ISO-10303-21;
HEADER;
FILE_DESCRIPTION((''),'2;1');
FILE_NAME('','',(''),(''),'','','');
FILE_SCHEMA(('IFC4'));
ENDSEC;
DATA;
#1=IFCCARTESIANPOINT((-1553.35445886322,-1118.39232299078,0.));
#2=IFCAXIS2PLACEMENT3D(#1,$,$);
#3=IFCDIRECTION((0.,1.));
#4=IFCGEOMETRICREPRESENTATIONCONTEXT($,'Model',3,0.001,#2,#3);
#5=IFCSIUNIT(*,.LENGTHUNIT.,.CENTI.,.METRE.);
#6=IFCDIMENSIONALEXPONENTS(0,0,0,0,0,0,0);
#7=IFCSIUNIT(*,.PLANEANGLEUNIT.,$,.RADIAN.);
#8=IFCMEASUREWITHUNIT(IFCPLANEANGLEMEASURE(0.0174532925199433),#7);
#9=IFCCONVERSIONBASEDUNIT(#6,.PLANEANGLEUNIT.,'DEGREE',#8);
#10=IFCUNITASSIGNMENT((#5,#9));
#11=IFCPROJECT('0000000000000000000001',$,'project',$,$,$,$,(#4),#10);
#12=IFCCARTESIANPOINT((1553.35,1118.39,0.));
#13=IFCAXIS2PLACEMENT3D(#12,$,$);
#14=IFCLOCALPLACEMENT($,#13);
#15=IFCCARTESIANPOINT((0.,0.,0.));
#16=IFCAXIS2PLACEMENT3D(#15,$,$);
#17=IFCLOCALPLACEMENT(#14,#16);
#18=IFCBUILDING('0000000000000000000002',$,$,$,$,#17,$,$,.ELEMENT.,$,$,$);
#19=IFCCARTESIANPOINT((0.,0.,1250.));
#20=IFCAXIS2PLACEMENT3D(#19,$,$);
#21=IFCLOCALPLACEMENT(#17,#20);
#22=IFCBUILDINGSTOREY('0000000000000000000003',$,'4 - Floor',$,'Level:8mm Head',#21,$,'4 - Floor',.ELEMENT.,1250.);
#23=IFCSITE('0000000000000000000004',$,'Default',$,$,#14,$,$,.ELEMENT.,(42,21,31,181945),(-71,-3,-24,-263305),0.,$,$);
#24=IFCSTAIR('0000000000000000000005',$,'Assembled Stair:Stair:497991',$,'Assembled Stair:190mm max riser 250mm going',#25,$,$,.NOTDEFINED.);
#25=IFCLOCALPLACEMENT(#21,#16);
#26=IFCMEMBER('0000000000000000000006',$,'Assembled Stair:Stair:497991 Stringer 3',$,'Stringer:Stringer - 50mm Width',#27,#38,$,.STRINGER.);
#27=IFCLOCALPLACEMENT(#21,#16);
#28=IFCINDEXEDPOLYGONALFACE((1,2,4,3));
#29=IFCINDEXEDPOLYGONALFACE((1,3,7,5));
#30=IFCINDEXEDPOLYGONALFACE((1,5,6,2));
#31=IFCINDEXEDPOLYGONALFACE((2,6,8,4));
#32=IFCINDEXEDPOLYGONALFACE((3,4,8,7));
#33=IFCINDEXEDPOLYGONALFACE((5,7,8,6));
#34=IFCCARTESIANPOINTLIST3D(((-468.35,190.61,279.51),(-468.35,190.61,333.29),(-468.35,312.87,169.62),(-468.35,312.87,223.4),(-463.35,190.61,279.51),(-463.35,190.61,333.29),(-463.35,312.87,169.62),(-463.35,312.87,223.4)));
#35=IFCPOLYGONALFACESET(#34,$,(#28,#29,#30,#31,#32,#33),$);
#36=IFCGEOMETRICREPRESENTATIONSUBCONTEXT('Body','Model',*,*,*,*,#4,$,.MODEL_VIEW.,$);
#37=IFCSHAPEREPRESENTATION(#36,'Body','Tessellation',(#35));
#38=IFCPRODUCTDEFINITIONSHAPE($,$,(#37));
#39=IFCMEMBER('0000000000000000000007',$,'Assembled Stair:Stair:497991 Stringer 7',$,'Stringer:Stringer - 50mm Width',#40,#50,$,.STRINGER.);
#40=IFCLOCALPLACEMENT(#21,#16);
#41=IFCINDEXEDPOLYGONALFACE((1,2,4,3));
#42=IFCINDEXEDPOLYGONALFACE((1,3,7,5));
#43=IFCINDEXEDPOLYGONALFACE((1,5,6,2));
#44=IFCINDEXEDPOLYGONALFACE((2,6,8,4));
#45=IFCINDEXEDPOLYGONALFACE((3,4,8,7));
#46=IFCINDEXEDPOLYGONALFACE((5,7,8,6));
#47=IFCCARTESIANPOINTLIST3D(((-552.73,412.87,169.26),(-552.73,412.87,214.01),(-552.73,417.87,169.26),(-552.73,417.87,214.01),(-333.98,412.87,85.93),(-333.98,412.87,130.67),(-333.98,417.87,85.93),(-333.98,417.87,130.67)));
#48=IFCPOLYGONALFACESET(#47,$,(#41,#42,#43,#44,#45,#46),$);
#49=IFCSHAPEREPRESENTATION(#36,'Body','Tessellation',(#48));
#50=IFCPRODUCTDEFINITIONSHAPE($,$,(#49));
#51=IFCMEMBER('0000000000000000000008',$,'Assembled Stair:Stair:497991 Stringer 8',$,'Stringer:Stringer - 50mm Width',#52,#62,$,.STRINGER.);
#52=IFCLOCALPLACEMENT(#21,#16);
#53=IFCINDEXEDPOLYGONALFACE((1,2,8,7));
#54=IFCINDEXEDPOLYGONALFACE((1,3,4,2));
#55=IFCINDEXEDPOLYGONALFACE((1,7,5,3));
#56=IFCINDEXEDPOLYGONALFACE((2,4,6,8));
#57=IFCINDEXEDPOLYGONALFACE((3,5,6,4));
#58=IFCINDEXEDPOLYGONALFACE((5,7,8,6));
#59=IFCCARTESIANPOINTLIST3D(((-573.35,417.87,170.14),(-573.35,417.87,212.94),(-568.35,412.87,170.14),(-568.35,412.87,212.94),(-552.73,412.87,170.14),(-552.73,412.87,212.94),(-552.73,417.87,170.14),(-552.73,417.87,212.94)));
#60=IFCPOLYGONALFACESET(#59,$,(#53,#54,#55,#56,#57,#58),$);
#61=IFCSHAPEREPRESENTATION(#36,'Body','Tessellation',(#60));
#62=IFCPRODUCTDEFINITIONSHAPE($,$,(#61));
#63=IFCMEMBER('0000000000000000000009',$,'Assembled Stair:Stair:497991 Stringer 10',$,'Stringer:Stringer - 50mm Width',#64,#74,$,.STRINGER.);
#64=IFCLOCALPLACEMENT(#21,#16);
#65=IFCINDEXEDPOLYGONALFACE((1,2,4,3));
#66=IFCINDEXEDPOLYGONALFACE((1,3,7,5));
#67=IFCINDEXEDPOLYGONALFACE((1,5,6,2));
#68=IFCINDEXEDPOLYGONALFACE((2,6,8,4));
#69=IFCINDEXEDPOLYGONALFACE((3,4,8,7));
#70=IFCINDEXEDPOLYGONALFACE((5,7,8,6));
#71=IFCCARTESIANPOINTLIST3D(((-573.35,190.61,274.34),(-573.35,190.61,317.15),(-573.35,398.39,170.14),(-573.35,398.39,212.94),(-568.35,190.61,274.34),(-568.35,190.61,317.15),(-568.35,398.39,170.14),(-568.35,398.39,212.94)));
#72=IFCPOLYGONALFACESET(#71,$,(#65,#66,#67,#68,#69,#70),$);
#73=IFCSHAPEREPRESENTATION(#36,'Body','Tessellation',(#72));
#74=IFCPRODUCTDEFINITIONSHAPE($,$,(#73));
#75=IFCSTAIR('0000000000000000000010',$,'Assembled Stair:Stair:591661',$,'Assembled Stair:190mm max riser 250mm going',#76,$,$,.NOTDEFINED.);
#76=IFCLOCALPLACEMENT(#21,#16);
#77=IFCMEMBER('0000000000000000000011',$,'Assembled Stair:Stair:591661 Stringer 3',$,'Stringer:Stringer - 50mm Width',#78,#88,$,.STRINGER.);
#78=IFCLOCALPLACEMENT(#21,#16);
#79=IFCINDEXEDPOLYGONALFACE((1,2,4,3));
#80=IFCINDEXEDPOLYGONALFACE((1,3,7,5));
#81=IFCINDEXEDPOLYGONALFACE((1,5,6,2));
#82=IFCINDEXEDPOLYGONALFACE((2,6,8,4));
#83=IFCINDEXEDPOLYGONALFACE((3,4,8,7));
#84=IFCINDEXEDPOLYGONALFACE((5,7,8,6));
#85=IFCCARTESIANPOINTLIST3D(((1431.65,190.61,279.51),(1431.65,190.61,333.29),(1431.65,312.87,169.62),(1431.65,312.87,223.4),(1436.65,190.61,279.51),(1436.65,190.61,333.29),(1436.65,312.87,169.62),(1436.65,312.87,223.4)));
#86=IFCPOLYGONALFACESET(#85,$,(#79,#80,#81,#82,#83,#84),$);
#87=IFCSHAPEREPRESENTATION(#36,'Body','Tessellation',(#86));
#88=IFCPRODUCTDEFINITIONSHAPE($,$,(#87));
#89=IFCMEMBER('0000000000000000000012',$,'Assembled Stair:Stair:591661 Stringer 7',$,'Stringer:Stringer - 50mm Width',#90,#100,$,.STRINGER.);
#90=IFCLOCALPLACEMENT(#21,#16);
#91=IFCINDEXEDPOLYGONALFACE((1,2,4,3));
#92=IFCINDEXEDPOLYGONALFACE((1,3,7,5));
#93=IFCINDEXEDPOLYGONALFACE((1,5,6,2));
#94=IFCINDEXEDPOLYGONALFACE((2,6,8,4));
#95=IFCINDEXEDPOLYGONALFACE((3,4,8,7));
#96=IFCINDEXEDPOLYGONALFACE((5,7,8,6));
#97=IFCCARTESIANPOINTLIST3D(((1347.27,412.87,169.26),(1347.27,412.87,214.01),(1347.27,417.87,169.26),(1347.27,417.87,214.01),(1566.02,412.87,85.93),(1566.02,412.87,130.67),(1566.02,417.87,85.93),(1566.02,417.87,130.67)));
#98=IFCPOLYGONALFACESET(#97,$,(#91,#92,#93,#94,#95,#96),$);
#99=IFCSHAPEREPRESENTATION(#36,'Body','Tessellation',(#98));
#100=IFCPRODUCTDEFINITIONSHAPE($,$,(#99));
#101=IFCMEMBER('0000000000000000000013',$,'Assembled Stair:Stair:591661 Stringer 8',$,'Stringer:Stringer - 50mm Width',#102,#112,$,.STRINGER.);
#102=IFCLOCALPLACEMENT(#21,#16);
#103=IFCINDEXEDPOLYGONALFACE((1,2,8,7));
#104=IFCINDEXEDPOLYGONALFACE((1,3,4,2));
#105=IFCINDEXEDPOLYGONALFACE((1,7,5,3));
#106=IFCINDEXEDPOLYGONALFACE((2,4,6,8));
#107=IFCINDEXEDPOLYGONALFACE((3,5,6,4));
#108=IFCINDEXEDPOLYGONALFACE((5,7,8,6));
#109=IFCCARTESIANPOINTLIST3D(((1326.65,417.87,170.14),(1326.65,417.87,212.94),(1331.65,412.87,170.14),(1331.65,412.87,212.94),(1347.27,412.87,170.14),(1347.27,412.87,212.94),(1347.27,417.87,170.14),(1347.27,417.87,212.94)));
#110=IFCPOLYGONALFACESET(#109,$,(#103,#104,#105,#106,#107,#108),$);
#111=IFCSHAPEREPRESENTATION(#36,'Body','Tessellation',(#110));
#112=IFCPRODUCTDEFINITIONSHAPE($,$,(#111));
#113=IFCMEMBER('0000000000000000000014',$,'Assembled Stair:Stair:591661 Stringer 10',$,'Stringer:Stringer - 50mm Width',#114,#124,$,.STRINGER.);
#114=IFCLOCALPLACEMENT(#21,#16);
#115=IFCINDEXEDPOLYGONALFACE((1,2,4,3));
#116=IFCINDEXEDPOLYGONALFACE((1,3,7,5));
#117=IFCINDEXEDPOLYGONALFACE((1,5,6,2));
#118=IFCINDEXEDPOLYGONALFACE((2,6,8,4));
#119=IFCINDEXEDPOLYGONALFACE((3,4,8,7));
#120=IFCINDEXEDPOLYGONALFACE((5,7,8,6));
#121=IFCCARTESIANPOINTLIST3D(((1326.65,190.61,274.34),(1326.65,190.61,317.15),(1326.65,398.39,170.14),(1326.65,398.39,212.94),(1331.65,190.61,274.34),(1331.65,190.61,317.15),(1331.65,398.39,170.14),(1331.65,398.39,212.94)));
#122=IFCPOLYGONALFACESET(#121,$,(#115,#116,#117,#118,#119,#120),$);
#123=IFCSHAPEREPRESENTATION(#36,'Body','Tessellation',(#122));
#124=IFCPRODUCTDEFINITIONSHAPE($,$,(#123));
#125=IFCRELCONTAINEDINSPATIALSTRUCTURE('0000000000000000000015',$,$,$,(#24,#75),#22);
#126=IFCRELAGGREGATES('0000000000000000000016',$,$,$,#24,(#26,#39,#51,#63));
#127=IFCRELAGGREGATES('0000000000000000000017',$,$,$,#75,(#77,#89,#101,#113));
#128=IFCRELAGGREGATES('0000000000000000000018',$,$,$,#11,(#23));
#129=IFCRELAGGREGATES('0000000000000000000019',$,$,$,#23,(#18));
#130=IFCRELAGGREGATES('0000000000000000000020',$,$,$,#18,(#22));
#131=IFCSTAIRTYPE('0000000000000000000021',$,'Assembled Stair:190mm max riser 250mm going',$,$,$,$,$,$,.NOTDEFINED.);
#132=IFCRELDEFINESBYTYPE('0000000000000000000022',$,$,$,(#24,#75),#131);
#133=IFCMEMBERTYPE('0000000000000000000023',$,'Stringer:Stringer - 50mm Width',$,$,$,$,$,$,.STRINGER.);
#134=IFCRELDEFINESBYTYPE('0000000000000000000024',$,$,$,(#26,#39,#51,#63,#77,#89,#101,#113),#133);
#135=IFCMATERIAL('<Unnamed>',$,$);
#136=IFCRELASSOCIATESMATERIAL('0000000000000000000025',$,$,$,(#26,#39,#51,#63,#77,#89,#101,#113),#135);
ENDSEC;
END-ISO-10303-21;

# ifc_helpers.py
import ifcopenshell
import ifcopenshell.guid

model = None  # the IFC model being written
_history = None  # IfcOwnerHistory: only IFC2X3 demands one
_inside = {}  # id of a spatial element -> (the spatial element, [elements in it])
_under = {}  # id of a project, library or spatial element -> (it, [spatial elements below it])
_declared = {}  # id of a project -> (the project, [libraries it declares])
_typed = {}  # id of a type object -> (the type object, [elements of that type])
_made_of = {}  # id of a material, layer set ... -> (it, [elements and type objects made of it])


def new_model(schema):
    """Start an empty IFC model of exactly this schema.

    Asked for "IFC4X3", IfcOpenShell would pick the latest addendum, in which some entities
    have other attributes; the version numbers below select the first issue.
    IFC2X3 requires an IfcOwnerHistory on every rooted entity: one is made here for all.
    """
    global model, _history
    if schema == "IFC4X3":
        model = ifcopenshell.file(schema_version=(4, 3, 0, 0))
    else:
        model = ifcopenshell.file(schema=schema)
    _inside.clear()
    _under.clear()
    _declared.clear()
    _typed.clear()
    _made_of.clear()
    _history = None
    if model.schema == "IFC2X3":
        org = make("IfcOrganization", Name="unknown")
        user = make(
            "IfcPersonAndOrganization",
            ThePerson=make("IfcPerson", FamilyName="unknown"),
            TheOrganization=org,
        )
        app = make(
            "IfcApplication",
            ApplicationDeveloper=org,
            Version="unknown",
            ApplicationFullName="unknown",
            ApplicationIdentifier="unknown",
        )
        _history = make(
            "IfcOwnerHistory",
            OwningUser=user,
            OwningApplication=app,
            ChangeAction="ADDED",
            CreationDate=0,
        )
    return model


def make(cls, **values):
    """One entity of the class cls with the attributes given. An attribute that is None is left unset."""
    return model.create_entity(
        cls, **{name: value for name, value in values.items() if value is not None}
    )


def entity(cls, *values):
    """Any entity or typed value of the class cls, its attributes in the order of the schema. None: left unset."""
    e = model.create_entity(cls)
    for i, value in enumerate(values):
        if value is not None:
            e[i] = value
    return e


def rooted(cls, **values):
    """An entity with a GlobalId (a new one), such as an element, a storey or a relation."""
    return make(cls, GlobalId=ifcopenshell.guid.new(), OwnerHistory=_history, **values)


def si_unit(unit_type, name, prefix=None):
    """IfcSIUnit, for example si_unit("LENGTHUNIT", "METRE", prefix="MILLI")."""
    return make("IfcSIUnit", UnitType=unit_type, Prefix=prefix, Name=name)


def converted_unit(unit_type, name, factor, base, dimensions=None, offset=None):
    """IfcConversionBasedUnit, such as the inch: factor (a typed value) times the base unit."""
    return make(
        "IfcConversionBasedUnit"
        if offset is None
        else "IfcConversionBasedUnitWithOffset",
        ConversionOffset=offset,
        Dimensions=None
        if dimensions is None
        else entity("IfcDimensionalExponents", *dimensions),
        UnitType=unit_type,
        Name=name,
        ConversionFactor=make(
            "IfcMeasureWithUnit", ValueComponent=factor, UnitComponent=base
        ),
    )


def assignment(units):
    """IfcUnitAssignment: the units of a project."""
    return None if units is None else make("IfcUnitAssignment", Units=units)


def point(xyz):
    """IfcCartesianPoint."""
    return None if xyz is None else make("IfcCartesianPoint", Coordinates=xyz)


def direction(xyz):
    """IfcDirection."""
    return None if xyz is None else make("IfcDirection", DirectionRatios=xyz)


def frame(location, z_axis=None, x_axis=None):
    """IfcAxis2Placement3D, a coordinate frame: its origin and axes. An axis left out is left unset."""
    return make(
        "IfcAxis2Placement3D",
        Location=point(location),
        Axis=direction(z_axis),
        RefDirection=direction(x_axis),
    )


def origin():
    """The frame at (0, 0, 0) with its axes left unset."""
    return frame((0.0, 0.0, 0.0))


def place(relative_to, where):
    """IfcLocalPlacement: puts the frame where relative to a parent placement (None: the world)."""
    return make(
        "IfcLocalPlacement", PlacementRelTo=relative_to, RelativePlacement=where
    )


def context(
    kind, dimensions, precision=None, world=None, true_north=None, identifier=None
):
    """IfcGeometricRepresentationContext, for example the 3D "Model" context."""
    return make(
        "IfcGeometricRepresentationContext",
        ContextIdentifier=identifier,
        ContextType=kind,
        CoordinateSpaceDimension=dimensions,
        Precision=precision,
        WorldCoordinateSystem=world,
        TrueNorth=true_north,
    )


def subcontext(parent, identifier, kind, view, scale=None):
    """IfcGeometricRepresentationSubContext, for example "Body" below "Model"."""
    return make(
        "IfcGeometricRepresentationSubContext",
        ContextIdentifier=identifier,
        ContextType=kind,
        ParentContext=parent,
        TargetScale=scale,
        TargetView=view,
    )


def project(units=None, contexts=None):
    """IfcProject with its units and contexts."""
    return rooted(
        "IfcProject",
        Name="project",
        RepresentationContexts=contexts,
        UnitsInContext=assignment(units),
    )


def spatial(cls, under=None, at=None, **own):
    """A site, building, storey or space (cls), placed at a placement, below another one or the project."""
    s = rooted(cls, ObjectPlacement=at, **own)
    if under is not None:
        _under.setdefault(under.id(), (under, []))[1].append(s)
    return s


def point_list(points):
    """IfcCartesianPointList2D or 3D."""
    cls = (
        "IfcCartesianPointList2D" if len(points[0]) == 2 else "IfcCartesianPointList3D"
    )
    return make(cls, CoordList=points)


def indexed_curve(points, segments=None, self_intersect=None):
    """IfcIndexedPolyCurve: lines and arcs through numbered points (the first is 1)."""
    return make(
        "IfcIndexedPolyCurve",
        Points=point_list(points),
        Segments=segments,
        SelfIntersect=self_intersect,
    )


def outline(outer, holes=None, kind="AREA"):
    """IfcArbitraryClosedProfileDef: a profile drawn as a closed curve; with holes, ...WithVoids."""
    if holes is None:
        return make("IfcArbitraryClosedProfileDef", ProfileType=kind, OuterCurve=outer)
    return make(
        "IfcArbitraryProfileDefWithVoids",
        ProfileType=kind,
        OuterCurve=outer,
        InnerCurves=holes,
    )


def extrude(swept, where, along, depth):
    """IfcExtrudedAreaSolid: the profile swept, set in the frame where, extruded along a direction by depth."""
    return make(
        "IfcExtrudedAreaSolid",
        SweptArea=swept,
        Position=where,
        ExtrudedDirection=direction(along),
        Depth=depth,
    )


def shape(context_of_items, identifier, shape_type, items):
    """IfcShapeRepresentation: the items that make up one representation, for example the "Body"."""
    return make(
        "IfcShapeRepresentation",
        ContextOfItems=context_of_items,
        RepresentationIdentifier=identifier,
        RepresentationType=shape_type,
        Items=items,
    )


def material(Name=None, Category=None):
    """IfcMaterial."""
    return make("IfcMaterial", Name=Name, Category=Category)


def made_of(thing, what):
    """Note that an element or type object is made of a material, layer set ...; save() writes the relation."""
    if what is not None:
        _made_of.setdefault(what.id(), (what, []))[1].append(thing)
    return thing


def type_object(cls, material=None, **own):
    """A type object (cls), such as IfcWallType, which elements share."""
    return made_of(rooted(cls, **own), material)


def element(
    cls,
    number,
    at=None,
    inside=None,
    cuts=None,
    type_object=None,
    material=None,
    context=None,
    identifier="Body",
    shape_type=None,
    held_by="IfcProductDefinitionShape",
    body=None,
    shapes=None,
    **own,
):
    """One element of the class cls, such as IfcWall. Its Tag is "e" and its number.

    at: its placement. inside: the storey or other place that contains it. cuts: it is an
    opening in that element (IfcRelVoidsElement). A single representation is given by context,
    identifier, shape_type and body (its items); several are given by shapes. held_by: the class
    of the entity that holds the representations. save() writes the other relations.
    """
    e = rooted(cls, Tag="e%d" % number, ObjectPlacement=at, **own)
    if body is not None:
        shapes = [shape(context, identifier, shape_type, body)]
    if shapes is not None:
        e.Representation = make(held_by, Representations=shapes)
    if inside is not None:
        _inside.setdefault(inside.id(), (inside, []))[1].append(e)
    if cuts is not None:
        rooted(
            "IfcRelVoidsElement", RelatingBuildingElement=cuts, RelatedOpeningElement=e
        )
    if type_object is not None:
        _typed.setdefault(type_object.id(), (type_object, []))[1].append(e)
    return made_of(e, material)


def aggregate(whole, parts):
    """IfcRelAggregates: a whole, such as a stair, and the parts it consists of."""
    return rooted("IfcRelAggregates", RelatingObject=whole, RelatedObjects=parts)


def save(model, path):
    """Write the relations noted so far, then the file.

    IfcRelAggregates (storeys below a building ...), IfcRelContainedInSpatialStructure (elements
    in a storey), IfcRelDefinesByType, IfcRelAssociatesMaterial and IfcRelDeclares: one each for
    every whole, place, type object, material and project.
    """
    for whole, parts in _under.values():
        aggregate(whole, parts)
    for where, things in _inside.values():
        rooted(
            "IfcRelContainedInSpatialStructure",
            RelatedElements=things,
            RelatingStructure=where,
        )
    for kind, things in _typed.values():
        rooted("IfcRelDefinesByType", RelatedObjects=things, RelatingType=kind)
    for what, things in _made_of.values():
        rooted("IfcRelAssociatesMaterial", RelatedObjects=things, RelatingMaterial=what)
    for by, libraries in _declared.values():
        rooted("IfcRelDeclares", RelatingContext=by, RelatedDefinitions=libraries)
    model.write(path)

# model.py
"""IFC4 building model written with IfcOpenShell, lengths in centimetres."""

from ifc_helpers import new_model, entity, si_unit, converted_unit, direction, frame, origin, place, context, subcontext, project, spatial, indexed_curve, outline, extrude, material, type_object, element, aggregate, save


model = new_model("IFC4")

# Units and contexts
model_context = context("Model", 3, precision=0.001, world=frame((-1553.35445886322, -1118.39232299078, 0.0)), true_north=direction((0.0, 1.0)))
body_context = subcontext(model_context, "Body", "Model", "MODEL_VIEW")
ifc_project = project(units=[si_unit("LENGTHUNIT", "METRE", prefix="CENTI"), converted_unit("PLANEANGLEUNIT", "DEGREE", entity("IfcPlaneAngleMeasure", 0.0174532925199433), si_unit("PLANEANGLEUNIT", "RADIAN"), dimensions=[0, 0, 0, 0, 0, 0, 0])], contexts=[model_context])

# Site, building, storey
site_placement = place(None, frame((1553.35, 1118.39, 0.0)))
site = spatial("IfcSite", under=ifc_project, at=site_placement, Name="Default", CompositionType="ELEMENT", RefLatitude=(42, 21, 31, 181945), RefLongitude=(-71, -3, -24, -263305), RefElevation=0.0)
building_placement = place(site_placement, origin())
building = spatial("IfcBuilding", under=site, at=building_placement, CompositionType="ELEMENT")
storey_placement = place(building_placement, frame((0.0, 0.0, 1250.0)))
storey = spatial("IfcBuildingStorey", under=building, at=storey_placement, Name="4 - Floor", ObjectType="Level:8mm Head", LongName="4 - Floor", CompositionType="ELEMENT", Elevation=1250.0)

# Stair, members
stair_type = type_object("IfcStairType", Name="Assembled Stair:190mm max riser 250mm going", PredefinedType="NOTDEFINED")
stair_1_placement = place(storey_placement, origin())
stair_1 = element("IfcStair", 1, at=stair_1_placement, inside=storey, type_object=stair_type, Name="Assembled Stair:Stair:497991", ObjectType="Assembled Stair:190mm max riser 250mm going", PredefinedType="NOTDEFINED")
ifc_material = material(Name="<Unnamed>")
member_type = type_object("IfcMemberType", Name="Stringer:Stringer - 50mm Width", PredefinedType="STRINGER")
member_1_placement = place(stair_1_placement, origin())
member_1 = element("IfcMember", 2, at=member_1_placement, type_object=member_type, material=ifc_material, Name="Assembled Stair:Stair:497991 Stringer 3", ObjectType="Stringer:Stringer - 50mm Width", PredefinedType="STRINGER", context=body_context, shape_type="SweptSolid", body=[
    extrude(outline(indexed_curve([(-64.22, -20.0), (100.17, -20.0), (64.22, 20.0), (-100.17, 20.0), (-64.22, -20.0)], self_intersect=False)), frame((-468.35, 251.74, 251.46), z_axis=(1.0, 0.0, 0.0), x_axis=(0.0, -0.74373, 0.668481)), (0.0, 0.0, 1.0), 5.0),
])
member_2_placement = place(stair_1_placement, origin())
member_2 = element("IfcMember", 3, at=member_2_placement, type_object=member_type, material=ifc_material, Name="Assembled Stair:Stair:497991 Stringer 7", ObjectType="Stringer:Stringer - 50mm Width", PredefinedType="STRINGER", context=body_context, shape_type="SweptSolid", body=[
    extrude(outline(indexed_curve([(-125.01, -20.91), (109.08, -20.91), (125.01, 20.91), (-109.08, 20.91), (-125.01, -20.91)], self_intersect=False)), frame((-443.35, 412.87, 149.97), z_axis=(0.0, 1.0, 0.0), x_axis=(-0.934489, 0.0, 0.355992)), (0.0, 0.0, 1.0), 5.0),
])
member_3_placement = place(stair_1_placement, origin())
member_3 = element("IfcMember", 4, at=member_3_placement, type_object=member_type, material=ifc_material, Name="Assembled Stair:Stair:497991 Stringer 8", ObjectType="Stringer:Stringer - 50mm Width", PredefinedType="STRINGER", context=body_context, shape_type="SweptSolid", body=[
    extrude(outline(indexed_curve([(-9.06, -2.5), (11.56, -2.5), (6.56, 2.5), (-9.06, 2.5), (-9.06, -2.5)], self_intersect=False)), frame((-561.79, 415.37, 170.14), z_axis=(0.0, 0.0, 1.0), x_axis=(-1.0, 0.0, 0.0)), (0.0, 0.0, 1.0), 42.8),
])
member_4_placement = place(stair_1_placement, origin())
member_4 = element("IfcMember", 5, at=member_4_placement, type_object=member_type, material=ifc_material, Name="Assembled Stair:Stair:497991 Stringer 10", ObjectType="Stringer:Stringer - 50mm Width", PredefinedType="STRINGER", context=body_context, shape_type="SweptSolid", body=[
    extrude(outline(indexed_curve([(-106.63, -19.13), (125.82, -19.13), (106.63, 19.13), (-125.82, 19.13), (-106.63, -19.13)], self_intersect=False)), frame((-573.35, 294.5, 243.64), z_axis=(1.0, 0.0, 0.0), x_axis=(0.0, -0.893886, 0.448294)), (0.0, 0.0, 1.0), 5.0),
])
aggregate(stair_1, [member_1, member_2, member_3, member_4])

# Stair, members
stair_2_placement = place(storey_placement, origin())
stair_2 = element("IfcStair", 6, at=stair_2_placement, inside=storey, type_object=stair_type, Name="Assembled Stair:Stair:591661", ObjectType="Assembled Stair:190mm max riser 250mm going", PredefinedType="NOTDEFINED")
member_5_placement = place(stair_2_placement, origin())
member_5 = element("IfcMember", 7, at=member_5_placement, type_object=member_type, material=ifc_material, Name="Assembled Stair:Stair:591661 Stringer 3", ObjectType="Stringer:Stringer - 50mm Width", PredefinedType="STRINGER", context=body_context, shape_type="SweptSolid", body=[
    extrude(outline(indexed_curve([(-64.22, -20.0), (100.17, -20.0), (64.22, 20.0), (-100.17, 20.0), (-64.22, -20.0)], self_intersect=False)), frame((1431.65, 251.74, 251.46), z_axis=(1.0, 0.0, 0.0), x_axis=(0.0, -0.74373, 0.668481)), (0.0, 0.0, 1.0), 5.0),
])
member_6_placement = place(stair_2_placement, origin())
member_6 = element("IfcMember", 8, at=member_6_placement, type_object=member_type, material=ifc_material, Name="Assembled Stair:Stair:591661 Stringer 7", ObjectType="Stringer:Stringer - 50mm Width", PredefinedType="STRINGER", context=body_context, shape_type="SweptSolid", body=[
    extrude(outline(indexed_curve([(-125.01, -20.91), (109.08, -20.91), (125.01, 20.91), (-109.08, 20.91), (-125.01, -20.91)], self_intersect=False)), frame((1456.65, 412.87, 149.97), z_axis=(0.0, 1.0, 0.0), x_axis=(-0.934489, 0.0, 0.355992)), (0.0, 0.0, 1.0), 5.0),
])
member_7_placement = place(stair_2_placement, origin())
member_7 = element("IfcMember", 9, at=member_7_placement, type_object=member_type, material=ifc_material, Name="Assembled Stair:Stair:591661 Stringer 8", ObjectType="Stringer:Stringer - 50mm Width", PredefinedType="STRINGER", context=body_context, shape_type="SweptSolid", body=[
    extrude(outline(indexed_curve([(-9.06, -2.5), (11.56, -2.5), (6.56, 2.5), (-9.06, 2.5), (-9.06, -2.5)], self_intersect=False)), frame((1338.21, 415.37, 170.14), z_axis=(0.0, 0.0, 1.0), x_axis=(-1.0, 0.0, 0.0)), (0.0, 0.0, 1.0), 42.8),
])
member_8_placement = place(stair_2_placement, origin())
member_8 = element("IfcMember", 10, at=member_8_placement, type_object=member_type, material=ifc_material, Name="Assembled Stair:Stair:591661 Stringer 10", ObjectType="Stringer:Stringer - 50mm Width", PredefinedType="STRINGER", context=body_context, shape_type="SweptSolid", body=[
    extrude(outline(indexed_curve([(-106.63, -19.13), (125.82, -19.13), (106.63, 19.13), (-125.82, 19.13), (-106.63, -19.13)], self_intersect=False)), frame((1326.65, 294.5, 243.64), z_axis=(1.0, 0.0, 0.0), x_axis=(0.0, -0.893886, 0.448294)), (0.0, 0.0, 1.0), 5.0),
])
aggregate(stair_2, [member_5, member_6, member_7, member_8])

save(model, "model.ifc")
